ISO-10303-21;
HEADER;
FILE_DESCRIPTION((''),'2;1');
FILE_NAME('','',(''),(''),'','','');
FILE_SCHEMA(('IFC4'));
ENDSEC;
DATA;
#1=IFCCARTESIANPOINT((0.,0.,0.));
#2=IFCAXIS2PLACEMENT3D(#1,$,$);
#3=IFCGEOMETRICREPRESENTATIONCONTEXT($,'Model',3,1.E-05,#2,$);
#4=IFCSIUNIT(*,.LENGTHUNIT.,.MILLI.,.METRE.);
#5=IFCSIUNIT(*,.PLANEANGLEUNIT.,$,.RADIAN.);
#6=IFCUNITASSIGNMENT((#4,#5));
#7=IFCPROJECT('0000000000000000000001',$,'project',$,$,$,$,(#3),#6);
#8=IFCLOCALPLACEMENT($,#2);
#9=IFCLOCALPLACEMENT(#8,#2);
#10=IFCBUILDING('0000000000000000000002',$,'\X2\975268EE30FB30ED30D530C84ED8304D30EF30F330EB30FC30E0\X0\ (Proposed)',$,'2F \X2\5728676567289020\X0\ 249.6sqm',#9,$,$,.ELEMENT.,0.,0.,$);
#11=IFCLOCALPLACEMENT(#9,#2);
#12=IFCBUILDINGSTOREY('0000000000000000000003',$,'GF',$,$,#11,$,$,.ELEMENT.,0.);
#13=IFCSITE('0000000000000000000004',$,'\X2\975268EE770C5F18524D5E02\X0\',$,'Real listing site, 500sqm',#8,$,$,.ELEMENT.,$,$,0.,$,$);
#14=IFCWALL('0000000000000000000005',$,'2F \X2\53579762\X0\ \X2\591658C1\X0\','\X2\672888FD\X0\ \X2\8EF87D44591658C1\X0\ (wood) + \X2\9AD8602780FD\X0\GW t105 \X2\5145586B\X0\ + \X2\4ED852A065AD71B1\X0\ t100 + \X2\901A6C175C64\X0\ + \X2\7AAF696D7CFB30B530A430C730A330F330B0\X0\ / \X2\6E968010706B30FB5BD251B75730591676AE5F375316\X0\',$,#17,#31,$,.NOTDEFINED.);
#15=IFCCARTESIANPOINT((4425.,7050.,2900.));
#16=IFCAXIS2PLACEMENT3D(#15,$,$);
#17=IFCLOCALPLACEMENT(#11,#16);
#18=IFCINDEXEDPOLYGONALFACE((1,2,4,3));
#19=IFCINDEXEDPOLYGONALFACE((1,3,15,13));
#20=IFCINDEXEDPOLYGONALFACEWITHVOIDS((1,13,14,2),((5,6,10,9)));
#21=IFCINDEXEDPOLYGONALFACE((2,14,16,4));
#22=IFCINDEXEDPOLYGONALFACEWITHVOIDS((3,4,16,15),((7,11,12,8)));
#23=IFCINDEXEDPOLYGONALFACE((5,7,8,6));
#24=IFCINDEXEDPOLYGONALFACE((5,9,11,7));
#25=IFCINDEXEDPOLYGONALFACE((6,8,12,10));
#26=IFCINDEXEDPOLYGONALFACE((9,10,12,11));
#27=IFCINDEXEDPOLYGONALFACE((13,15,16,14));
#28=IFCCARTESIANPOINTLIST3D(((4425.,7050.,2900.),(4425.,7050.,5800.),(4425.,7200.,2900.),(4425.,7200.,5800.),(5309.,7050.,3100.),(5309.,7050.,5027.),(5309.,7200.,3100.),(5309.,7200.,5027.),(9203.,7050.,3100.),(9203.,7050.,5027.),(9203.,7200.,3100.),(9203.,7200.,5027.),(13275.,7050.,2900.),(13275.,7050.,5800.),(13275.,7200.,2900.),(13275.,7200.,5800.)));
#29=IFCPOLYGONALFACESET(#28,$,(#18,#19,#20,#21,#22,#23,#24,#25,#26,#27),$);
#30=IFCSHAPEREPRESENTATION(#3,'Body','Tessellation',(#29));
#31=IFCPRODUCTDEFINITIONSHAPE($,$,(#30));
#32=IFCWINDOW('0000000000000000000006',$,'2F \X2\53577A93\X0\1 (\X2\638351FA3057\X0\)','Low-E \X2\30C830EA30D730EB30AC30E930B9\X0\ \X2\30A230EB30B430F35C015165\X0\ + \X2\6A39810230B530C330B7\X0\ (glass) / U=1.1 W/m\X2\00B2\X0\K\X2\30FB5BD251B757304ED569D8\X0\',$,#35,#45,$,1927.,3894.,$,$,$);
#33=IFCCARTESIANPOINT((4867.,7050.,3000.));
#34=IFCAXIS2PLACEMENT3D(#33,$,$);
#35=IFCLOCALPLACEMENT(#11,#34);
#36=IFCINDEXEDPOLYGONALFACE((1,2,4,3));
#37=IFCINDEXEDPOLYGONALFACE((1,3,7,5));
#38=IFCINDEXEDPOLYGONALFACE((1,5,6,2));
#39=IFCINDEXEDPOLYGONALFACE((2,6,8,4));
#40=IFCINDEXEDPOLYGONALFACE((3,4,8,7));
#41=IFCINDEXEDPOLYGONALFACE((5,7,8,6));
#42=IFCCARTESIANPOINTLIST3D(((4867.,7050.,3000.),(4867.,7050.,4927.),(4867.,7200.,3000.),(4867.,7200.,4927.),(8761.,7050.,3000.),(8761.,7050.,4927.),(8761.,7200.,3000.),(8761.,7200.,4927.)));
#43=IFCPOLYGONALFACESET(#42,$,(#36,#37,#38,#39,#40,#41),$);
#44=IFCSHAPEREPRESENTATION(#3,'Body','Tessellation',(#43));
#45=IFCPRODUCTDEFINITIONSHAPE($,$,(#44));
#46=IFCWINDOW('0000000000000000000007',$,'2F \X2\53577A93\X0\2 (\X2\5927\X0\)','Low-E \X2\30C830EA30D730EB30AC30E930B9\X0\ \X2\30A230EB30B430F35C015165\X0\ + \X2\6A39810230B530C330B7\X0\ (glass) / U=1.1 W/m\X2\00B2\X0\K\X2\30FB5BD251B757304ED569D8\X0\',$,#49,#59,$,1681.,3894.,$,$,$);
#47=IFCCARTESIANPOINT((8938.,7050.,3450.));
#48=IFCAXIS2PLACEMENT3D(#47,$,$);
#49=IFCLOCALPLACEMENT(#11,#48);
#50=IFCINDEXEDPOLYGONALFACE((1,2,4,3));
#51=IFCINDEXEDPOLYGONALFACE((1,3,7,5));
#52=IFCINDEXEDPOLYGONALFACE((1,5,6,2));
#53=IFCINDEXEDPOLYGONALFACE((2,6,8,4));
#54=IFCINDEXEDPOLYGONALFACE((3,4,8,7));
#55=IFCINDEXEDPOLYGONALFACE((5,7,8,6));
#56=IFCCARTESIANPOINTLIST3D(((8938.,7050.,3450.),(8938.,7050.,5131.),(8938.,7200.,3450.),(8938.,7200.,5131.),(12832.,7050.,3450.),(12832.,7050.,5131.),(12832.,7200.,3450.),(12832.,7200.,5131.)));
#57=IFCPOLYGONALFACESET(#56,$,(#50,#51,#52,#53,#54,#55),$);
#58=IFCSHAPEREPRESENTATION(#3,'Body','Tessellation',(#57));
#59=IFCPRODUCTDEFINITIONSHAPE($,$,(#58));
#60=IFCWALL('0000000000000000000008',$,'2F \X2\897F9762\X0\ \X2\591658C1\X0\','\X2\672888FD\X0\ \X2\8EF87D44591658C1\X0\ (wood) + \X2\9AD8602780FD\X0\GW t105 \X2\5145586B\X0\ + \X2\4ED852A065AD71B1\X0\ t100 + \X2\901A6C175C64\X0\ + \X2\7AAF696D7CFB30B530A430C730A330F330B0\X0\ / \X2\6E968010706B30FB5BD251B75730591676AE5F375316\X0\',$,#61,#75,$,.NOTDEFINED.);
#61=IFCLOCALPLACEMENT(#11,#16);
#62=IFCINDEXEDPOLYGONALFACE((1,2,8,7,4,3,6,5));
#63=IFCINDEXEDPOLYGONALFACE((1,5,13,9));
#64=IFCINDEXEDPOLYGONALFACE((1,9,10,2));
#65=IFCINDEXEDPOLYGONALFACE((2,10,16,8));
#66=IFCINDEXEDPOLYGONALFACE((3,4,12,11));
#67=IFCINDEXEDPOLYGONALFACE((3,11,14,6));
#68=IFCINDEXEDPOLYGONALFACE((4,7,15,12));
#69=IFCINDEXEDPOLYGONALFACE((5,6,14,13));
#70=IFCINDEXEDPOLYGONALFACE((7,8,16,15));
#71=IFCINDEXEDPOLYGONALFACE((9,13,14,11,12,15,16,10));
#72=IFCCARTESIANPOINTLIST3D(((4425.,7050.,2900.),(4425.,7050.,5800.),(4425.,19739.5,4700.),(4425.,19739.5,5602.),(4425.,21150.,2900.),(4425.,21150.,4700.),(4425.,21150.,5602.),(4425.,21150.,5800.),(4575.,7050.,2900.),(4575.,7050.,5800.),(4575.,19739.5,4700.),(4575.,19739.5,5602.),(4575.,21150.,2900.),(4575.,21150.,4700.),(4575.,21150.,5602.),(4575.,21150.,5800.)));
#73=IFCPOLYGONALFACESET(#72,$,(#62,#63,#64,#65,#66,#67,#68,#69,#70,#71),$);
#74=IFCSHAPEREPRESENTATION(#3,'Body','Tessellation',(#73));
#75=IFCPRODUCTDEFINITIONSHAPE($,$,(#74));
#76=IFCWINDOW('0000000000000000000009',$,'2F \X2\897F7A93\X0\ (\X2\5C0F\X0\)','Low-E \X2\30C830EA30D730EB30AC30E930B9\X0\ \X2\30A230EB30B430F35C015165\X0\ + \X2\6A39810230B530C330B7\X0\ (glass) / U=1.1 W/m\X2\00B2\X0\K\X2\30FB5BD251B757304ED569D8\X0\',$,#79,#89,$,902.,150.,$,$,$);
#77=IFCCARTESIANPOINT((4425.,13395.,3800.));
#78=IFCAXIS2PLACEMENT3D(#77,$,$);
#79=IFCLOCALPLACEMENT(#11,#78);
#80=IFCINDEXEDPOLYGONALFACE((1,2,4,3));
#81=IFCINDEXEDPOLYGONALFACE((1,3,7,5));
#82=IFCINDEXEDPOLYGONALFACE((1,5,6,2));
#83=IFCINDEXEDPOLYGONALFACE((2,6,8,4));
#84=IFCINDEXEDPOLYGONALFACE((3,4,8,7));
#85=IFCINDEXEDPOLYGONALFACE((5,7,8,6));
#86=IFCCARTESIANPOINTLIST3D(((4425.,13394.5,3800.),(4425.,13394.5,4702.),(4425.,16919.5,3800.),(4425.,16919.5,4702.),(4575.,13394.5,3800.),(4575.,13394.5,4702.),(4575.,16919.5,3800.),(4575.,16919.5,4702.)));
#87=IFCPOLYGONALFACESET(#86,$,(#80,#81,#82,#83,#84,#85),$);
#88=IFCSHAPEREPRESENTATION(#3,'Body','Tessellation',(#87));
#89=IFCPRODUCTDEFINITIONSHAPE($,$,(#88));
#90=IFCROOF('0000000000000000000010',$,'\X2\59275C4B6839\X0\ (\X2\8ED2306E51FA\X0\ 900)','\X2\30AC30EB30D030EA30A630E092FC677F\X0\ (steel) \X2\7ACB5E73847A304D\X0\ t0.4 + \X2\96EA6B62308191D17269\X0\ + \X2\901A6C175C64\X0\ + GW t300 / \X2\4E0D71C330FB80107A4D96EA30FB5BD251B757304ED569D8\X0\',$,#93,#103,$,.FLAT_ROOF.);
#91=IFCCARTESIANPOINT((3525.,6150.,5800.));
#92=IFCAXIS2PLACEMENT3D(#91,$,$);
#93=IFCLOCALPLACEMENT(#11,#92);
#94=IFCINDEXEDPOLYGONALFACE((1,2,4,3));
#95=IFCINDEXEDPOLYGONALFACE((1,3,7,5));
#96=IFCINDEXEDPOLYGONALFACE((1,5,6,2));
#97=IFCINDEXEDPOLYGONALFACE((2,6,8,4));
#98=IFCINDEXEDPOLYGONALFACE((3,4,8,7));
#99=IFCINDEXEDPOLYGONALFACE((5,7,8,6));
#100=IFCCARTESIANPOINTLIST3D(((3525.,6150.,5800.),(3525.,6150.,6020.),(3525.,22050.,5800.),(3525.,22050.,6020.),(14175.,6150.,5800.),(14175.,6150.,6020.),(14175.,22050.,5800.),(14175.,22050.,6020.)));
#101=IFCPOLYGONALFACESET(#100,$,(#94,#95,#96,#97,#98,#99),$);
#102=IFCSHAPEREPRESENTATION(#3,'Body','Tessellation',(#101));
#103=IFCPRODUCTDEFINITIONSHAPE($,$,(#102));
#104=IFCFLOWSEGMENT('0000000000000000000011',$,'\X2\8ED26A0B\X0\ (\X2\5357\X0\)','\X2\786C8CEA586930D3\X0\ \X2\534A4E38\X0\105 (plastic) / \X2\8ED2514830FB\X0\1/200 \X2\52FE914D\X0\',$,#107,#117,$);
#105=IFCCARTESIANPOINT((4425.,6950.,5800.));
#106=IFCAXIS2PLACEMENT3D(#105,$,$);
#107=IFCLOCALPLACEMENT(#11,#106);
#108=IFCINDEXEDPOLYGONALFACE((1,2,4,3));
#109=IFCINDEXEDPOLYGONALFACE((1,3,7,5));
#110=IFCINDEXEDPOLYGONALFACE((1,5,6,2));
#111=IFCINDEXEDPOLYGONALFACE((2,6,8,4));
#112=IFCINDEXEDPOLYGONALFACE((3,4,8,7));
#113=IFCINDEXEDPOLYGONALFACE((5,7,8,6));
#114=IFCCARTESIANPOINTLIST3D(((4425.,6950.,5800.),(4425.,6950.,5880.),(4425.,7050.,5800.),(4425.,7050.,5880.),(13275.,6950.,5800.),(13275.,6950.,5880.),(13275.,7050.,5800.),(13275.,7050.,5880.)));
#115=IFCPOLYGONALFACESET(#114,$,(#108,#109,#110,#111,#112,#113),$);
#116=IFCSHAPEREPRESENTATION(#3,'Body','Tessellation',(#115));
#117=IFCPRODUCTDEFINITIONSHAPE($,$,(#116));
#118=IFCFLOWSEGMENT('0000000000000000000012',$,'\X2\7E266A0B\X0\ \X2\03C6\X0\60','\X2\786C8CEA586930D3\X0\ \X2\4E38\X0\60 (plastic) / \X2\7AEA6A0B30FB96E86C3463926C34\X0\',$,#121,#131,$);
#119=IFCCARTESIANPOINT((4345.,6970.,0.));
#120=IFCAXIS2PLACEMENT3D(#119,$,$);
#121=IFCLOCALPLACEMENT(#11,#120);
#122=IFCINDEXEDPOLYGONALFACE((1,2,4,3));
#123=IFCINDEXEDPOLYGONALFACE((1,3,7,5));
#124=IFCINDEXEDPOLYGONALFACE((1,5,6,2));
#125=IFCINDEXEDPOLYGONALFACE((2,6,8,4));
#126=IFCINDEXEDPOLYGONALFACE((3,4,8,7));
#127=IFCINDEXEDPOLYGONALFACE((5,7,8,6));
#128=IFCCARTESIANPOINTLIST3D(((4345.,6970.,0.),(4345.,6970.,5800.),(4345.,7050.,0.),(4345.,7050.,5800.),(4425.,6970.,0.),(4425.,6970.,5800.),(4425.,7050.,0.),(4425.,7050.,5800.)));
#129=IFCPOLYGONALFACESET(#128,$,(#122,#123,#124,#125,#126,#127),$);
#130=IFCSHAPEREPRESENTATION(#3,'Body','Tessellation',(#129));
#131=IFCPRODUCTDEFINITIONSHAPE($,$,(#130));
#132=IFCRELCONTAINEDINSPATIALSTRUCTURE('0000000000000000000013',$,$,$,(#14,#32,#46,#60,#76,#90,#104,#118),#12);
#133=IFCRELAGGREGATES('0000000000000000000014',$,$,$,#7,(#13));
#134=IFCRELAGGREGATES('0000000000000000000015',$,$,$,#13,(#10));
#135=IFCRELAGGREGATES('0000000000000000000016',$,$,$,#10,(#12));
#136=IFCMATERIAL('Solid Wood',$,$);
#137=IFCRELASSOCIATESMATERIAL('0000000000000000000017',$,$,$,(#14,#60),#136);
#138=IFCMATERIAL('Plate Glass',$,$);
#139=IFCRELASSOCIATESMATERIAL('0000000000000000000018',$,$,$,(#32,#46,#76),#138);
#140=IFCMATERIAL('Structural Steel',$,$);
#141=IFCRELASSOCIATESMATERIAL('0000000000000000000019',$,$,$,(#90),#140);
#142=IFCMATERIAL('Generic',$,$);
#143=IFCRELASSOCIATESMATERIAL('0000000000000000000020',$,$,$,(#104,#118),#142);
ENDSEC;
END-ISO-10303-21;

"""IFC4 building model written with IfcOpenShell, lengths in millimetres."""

from ifc_helpers import new_model, si_unit, frame, frame_2d, origin, place, context, project, spatial, rectangle, extrude, material, element, fill, save


model = new_model("IFC4")

# Units and contexts
model_context = context("Model", 3, precision=1e-05, world=origin())
ifc_project = project(units=[si_unit("LENGTHUNIT", "METRE", prefix="MILLI"), si_unit("PLANEANGLEUNIT", "RADIAN")], contexts=[model_context])

# Site, building, storey
site_placement = place(None, origin())
site = spatial("IfcSite", under=ifc_project, at=site_placement, Name="青森県弘前市", ObjectType="Real listing site, 500sqm", CompositionType="ELEMENT", RefElevation=0.0)
building_placement = place(site_placement, origin())
building = spatial("IfcBuilding", under=site, at=building_placement, Name="青森・ロフト付きワンルーム (Proposed)", ObjectType="2F 在来木造 249.6sqm", CompositionType="ELEMENT", ElevationOfRefHeight=0.0, ElevationOfTerrain=0.0)
storey_placement = place(building_placement, origin())
storey = spatial("IfcBuildingStorey", under=building, at=storey_placement, Name="GF", CompositionType="ELEMENT", Elevation=0.0)

# Shared definitions
ifc_material_1 = material(Name="Solid Wood")

# Shared definitions
ifc_material_2 = material(Name="Plate Glass")

# Wall, openings, windows
wall_1_placement = place(storey_placement, frame((4425.0, 7050.0, 2900.0)))
wall_1 = element("IfcWall", 1, at=wall_1_placement, inside=storey, material=ifc_material_1, Name="2F 南面 外壁", Description="木製 軸組外壁 (wood) + 高性能GW t105 充填 + 付加断熱 t100 + 通気層 + 窯業系サイディング / 準耐火・寒冷地外皮強化", PredefinedType="NOTDEFINED", context=model_context, shape_type="SweptSolid", body=[
    extrude(rectangle(XDim=8850.0, YDim=150.0, at=frame_2d((4425.0, 75.0))), frame((4425.0, 7050.0, 2900.0)), (0.0, 0.0, 1.0), 2900.0),
])
opening_1_placement = place(storey_placement, frame((4867.0, 7050.0, 3000.0)))
opening_1 = element("IfcOpeningElement", 2, at=opening_1_placement, cuts=wall_1, PredefinedType="NOTDEFINED", context=model_context, shape_type="SweptSolid", body=[
    extrude(rectangle(XDim=3894.0, YDim=150.0, at=frame_2d((1947.0, 75.0))), frame((4867.0, 7050.0, 3000.0)), (0.0, 0.0, 1.0), 1927.0),
])
opening_2_placement = place(storey_placement, frame((8938.0, 7050.0, 3450.0)))
opening_2 = element("IfcOpeningElement", 3, at=opening_2_placement, cuts=wall_1, PredefinedType="NOTDEFINED", context=model_context, shape_type="SweptSolid", body=[
    extrude(rectangle(XDim=3894.0, YDim=150.0, at=frame_2d((1947.0, 75.0))), frame((8938.0, 7050.0, 3450.0)), (0.0, 0.0, 1.0), 1681.0),
])
window_1_placement = place(storey_placement, frame((4867.0, 7050.0, 3000.0)))
window_1 = element("IfcWindow", 4, at=window_1_placement, inside=storey, material=ifc_material_2, Name="2F 南窓1 (掃出し)", Description="Low-E トリプルガラス アルゴン封入 + 樹脂サッシ (glass) / U=1.1 W/m²K・寒冷地仕様", OverallHeight=1927.0, OverallWidth=3894.0, context=model_context, shape_type="SweptSolid", body=[
    extrude(rectangle(XDim=3894.0, YDim=150.0, at=frame_2d((1947.0, 75.0))), frame((4867.0, 7050.0, 3000.0)), (0.0, 0.0, 1.0), 1927.0),
])
fill(opening_1, window_1)
window_2_placement = place(storey_placement, frame((8938.0, 7050.0, 3450.0)))
window_2 = element("IfcWindow", 5, at=window_2_placement, inside=storey, material=ifc_material_2, Name="2F 南窓2 (大)", Description="Low-E トリプルガラス アルゴン封入 + 樹脂サッシ (glass) / U=1.1 W/m²K・寒冷地仕様", OverallHeight=1681.0, OverallWidth=3894.0, context=model_context, shape_type="SweptSolid", body=[
    extrude(rectangle(XDim=3894.0, YDim=150.0, at=frame_2d((1947.0, 75.0))), frame((8938.0, 7050.0, 3450.0)), (0.0, 0.0, 1.0), 1681.0),
])
fill(opening_2, window_2)

# Wall, opening, window
wall_2_placement = place(storey_placement, frame((4425.0, 7050.0, 2900.0)))
wall_2 = element("IfcWall", 6, at=wall_2_placement, inside=storey, material=ifc_material_1, Name="2F 西面 外壁", Description="木製 軸組外壁 (wood) + 高性能GW t105 充填 + 付加断熱 t100 + 通気層 + 窯業系サイディング / 準耐火・寒冷地外皮強化", PredefinedType="NOTDEFINED", context=model_context, shape_type="SweptSolid", body=[
    extrude(rectangle(XDim=150.0, YDim=14100.0, at=frame_2d((75.0, 7050.0))), frame((4425.0, 7050.0, 2900.0)), (0.0, 0.0, 1.0), 2900.0),
])
opening_3_placement = place(storey_placement, frame((4425.0, 13395.0, 3800.0)))
opening_3 = element("IfcOpeningElement", 7, at=opening_3_placement, cuts=wall_2, PredefinedType="NOTDEFINED", context=model_context, shape_type="SweptSolid", body=[
    extrude(rectangle(XDim=150.0, YDim=3525.0, at=frame_2d((75.0, 1762.0))), frame((4425.0, 13395.0, 3800.0)), (0.0, 0.0, 1.0), 902.0),
])
window_3_placement = place(storey_placement, frame((4425.0, 13395.0, 3800.0)))
window_3 = element("IfcWindow", 8, at=window_3_placement, inside=storey, material=ifc_material_2, Name="2F 西窓 (小)", Description="Low-E トリプルガラス アルゴン封入 + 樹脂サッシ (glass) / U=1.1 W/m²K・寒冷地仕様", OverallHeight=902.0, OverallWidth=150.0, context=model_context, shape_type="SweptSolid", body=[
    extrude(rectangle(XDim=150.0, YDim=3525.0, at=frame_2d((75.0, 1762.0))), frame((4425.0, 13395.0, 3800.0)), (0.0, 0.0, 1.0), 902.0),
])
fill(opening_3, window_3)

# Roof
ifc_material_3 = material(Name="Structural Steel")
roof_placement = place(storey_placement, frame((3525.0, 6150.0, 5800.0)))
element("IfcRoof", 9, at=roof_placement, inside=storey, material=ifc_material_3, Name="大屋根 (軒の出 900)", Description="ガルバリウム鋼板 (steel) 立平葺き t0.4 + 雪止め金物 + 通気層 + GW t300 / 不燃・耐積雪・寒冷地仕様", PredefinedType="FLAT_ROOF", context=model_context, shape_type="SweptSolid", body=[
    extrude(rectangle(XDim=10650.0, YDim=15900.0, at=frame_2d((5325.0, 7950.0))), frame((3525.0, 6150.0, 5800.0)), (0.0, 0.0, 1.0), 220.0),
])

# Flow segments
ifc_material_4 = material(Name="Generic")
flow_segment_1_placement = place(storey_placement, frame((4425.0, 6950.0, 5800.0)))
element("IfcFlowSegment", 10, at=flow_segment_1_placement, inside=storey, material=ifc_material_4, Name="軒樋 (南)", Description="硬質塩ビ 半丸105 (plastic) / 軒先・1/200 勾配", context=model_context, shape_type="SweptSolid", body=[
    extrude(rectangle(XDim=8850.0, YDim=100.0, at=frame_2d((4425.0, 50.0))), frame((4425.0, 6950.0, 5800.0)), (0.0, 0.0, 1.0), 80.0),
])
flow_segment_2_placement = place(storey_placement, frame((4345.0, 6970.0, 0.0)))
element("IfcFlowSegment", 11, at=flow_segment_2_placement, inside=storey, material=ifc_material_4, Name="縦樋 φ60", Description="硬質塩ビ 丸60 (plastic) / 竪樋・雨水排水", context=model_context, shape_type="SweptSolid", body=[
    extrude(rectangle(XDim=80.0, YDim=80.0, at=frame_2d((40.0, 40.0))), frame((4345.0, 6970.0, 0.0)), (0.0, 0.0, 1.0), 5800.0),
])

save(model, "model.ifc")
